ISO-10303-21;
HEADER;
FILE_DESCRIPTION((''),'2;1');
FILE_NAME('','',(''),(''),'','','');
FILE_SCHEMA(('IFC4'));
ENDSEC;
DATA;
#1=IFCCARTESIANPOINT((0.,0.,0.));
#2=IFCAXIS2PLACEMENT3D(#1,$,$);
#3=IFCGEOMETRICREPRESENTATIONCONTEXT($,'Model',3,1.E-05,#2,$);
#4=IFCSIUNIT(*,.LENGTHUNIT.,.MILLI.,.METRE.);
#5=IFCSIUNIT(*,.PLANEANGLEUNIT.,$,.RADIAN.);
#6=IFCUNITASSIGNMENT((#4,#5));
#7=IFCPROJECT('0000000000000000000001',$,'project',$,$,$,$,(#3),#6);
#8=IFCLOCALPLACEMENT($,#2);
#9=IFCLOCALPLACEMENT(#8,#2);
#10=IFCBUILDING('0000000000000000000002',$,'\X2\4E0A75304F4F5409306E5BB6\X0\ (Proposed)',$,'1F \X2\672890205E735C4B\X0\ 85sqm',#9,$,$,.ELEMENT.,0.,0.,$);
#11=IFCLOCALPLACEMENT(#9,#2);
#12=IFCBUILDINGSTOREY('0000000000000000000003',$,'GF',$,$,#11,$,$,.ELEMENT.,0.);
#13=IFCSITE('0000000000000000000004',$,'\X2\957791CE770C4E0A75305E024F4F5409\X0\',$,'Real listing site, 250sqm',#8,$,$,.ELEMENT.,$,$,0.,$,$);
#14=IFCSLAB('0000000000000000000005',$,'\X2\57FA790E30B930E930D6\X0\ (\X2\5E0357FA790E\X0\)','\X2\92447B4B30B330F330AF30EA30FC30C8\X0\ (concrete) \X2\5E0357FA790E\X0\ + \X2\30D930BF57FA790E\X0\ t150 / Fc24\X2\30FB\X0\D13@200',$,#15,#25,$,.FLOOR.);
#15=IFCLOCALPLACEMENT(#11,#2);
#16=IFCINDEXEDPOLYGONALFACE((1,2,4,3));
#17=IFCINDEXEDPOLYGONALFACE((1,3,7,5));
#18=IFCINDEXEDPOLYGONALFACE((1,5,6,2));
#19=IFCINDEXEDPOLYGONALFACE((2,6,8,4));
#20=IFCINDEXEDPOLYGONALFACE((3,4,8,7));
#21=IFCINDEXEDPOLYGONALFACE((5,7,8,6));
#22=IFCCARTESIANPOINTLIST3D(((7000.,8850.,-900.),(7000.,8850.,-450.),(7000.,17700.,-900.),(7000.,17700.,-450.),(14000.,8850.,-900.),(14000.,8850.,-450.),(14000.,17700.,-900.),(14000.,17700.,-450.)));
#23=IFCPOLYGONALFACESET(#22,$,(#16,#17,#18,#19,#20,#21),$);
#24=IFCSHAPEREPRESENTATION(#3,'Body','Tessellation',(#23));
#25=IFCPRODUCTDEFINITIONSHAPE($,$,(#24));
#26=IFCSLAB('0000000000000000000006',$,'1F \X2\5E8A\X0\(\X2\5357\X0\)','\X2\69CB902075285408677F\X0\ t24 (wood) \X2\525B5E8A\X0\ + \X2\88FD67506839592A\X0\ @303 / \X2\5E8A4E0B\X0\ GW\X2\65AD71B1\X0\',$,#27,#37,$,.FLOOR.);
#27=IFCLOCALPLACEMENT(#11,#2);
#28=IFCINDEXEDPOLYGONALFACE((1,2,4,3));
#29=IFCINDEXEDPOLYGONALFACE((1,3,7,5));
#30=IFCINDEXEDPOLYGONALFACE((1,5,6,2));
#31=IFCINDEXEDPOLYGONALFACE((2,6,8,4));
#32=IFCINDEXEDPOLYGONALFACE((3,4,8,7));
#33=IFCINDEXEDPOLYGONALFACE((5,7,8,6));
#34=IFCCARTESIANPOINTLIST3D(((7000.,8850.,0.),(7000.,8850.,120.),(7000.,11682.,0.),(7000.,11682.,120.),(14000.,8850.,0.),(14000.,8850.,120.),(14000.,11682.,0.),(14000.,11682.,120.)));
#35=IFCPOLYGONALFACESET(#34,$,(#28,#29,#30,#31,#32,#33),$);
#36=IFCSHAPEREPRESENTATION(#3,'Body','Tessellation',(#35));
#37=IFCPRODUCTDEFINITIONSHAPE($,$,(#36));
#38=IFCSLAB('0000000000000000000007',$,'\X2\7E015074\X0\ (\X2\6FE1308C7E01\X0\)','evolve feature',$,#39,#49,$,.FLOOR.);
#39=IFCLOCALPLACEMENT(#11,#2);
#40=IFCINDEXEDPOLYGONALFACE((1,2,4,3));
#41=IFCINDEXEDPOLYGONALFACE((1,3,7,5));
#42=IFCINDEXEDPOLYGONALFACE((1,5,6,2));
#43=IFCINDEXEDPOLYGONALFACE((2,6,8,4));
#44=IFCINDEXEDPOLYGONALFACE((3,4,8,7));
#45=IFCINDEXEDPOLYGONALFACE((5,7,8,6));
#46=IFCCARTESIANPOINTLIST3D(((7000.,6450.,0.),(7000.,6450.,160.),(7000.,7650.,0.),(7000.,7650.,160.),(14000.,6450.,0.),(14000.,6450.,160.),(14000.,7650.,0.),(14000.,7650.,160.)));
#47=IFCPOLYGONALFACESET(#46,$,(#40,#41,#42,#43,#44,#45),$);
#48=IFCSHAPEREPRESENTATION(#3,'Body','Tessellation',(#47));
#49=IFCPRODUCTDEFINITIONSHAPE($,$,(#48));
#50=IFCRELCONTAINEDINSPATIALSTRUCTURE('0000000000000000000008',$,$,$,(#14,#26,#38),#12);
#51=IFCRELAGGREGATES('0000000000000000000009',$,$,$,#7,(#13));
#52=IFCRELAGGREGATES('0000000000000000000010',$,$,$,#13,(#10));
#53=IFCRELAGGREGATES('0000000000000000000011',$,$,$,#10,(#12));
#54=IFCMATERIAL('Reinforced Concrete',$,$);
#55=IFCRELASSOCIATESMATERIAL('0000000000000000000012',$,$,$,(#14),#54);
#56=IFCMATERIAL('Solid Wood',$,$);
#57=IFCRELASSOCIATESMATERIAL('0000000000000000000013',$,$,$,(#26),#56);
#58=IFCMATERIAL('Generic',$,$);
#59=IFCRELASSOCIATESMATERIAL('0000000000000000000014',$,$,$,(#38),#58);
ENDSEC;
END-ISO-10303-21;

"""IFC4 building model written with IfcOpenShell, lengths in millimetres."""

from ifc_helpers import new_model, si_unit, frame, frame_2d, origin, place, context, project, spatial, rectangle, extrude, material, element, save


model = new_model("IFC4")

# Units and contexts
model_context = context("Model", 3, precision=1e-05, world=origin())
ifc_project = project(units=[si_unit("LENGTHUNIT", "METRE", prefix="MILLI"), si_unit("PLANEANGLEUNIT", "RADIAN")], contexts=[model_context])

# Site, building, storey
site_placement = place(None, origin())
site = spatial("IfcSite", under=ifc_project, at=site_placement, Name="長野県上田市住吉", ObjectType="Real listing site, 250sqm", CompositionType="ELEMENT", RefElevation=0.0)
building_placement = place(site_placement, origin())
building = spatial("IfcBuilding", under=site, at=building_placement, Name="上田住吉の家 (Proposed)", ObjectType="1F 木造平屋 85sqm", CompositionType="ELEMENT", ElevationOfRefHeight=0.0, ElevationOfTerrain=0.0)
storey_placement = place(building_placement, origin())
storey = spatial("IfcBuildingStorey", under=building, at=storey_placement, Name="GF", CompositionType="ELEMENT", Elevation=0.0)

# Slabs
ifc_material_1 = material(Name="Reinforced Concrete")
slab_1_placement = place(storey_placement, frame((3500.0, 4425.0, -450.0)))
element("IfcSlab", 1, at=slab_1_placement, inside=storey, material=ifc_material_1, Name="基礎スラブ (布基礎)", Description="鉄筋コンクリート (concrete) 布基礎 + ベタ基礎 t150 / Fc24・D13@200", PredefinedType="FLOOR", context=model_context, shape_type="SweptSolid", body=[
    extrude(rectangle(XDim=7000.0, YDim=8850.0, at=frame_2d((3500.0, 4425.0))), frame((3500.0, 4425.0, -450.0)), (0.0, 0.0, 1.0), 450.0),
])
ifc_material_2 = material(Name="Solid Wood")
slab_2_placement = place(storey_placement, frame((3500.0, 4425.0, 0.0)))
element("IfcSlab", 2, at=slab_2_placement, inside=storey, material=ifc_material_2, Name="1F 床(南)", Description="構造用合板 t24 (wood) 剛床 + 製材根太 @303 / 床下 GW断熱", PredefinedType="FLOOR", context=model_context, shape_type="SweptSolid", body=[
    extrude(rectangle(XDim=7000.0, YDim=2832.0, at=frame_2d((3500.0, 1416.0))), frame((3500.0, 4425.0, 0.0)), (0.0, 0.0, 1.0), 120.0),
])
ifc_material_3 = material(Name="Generic")
slab_3_placement = place(storey_placement, frame((3500.0, 3225.0, 0.0)))
element("IfcSlab", 3, at=slab_3_placement, inside=storey, material=ifc_material_3, Name="縁側 (濡れ縁)", Description="evolve feature", PredefinedType="FLOOR", context=model_context, shape_type="SweptSolid", body=[
    extrude(rectangle(XDim=7000.0, YDim=1200.0, at=frame_2d((3500.0, 600.0))), frame((3500.0, 3225.0, 0.0)), (0.0, 0.0, 1.0), 160.0),
])

save(model, "model.ifc")
